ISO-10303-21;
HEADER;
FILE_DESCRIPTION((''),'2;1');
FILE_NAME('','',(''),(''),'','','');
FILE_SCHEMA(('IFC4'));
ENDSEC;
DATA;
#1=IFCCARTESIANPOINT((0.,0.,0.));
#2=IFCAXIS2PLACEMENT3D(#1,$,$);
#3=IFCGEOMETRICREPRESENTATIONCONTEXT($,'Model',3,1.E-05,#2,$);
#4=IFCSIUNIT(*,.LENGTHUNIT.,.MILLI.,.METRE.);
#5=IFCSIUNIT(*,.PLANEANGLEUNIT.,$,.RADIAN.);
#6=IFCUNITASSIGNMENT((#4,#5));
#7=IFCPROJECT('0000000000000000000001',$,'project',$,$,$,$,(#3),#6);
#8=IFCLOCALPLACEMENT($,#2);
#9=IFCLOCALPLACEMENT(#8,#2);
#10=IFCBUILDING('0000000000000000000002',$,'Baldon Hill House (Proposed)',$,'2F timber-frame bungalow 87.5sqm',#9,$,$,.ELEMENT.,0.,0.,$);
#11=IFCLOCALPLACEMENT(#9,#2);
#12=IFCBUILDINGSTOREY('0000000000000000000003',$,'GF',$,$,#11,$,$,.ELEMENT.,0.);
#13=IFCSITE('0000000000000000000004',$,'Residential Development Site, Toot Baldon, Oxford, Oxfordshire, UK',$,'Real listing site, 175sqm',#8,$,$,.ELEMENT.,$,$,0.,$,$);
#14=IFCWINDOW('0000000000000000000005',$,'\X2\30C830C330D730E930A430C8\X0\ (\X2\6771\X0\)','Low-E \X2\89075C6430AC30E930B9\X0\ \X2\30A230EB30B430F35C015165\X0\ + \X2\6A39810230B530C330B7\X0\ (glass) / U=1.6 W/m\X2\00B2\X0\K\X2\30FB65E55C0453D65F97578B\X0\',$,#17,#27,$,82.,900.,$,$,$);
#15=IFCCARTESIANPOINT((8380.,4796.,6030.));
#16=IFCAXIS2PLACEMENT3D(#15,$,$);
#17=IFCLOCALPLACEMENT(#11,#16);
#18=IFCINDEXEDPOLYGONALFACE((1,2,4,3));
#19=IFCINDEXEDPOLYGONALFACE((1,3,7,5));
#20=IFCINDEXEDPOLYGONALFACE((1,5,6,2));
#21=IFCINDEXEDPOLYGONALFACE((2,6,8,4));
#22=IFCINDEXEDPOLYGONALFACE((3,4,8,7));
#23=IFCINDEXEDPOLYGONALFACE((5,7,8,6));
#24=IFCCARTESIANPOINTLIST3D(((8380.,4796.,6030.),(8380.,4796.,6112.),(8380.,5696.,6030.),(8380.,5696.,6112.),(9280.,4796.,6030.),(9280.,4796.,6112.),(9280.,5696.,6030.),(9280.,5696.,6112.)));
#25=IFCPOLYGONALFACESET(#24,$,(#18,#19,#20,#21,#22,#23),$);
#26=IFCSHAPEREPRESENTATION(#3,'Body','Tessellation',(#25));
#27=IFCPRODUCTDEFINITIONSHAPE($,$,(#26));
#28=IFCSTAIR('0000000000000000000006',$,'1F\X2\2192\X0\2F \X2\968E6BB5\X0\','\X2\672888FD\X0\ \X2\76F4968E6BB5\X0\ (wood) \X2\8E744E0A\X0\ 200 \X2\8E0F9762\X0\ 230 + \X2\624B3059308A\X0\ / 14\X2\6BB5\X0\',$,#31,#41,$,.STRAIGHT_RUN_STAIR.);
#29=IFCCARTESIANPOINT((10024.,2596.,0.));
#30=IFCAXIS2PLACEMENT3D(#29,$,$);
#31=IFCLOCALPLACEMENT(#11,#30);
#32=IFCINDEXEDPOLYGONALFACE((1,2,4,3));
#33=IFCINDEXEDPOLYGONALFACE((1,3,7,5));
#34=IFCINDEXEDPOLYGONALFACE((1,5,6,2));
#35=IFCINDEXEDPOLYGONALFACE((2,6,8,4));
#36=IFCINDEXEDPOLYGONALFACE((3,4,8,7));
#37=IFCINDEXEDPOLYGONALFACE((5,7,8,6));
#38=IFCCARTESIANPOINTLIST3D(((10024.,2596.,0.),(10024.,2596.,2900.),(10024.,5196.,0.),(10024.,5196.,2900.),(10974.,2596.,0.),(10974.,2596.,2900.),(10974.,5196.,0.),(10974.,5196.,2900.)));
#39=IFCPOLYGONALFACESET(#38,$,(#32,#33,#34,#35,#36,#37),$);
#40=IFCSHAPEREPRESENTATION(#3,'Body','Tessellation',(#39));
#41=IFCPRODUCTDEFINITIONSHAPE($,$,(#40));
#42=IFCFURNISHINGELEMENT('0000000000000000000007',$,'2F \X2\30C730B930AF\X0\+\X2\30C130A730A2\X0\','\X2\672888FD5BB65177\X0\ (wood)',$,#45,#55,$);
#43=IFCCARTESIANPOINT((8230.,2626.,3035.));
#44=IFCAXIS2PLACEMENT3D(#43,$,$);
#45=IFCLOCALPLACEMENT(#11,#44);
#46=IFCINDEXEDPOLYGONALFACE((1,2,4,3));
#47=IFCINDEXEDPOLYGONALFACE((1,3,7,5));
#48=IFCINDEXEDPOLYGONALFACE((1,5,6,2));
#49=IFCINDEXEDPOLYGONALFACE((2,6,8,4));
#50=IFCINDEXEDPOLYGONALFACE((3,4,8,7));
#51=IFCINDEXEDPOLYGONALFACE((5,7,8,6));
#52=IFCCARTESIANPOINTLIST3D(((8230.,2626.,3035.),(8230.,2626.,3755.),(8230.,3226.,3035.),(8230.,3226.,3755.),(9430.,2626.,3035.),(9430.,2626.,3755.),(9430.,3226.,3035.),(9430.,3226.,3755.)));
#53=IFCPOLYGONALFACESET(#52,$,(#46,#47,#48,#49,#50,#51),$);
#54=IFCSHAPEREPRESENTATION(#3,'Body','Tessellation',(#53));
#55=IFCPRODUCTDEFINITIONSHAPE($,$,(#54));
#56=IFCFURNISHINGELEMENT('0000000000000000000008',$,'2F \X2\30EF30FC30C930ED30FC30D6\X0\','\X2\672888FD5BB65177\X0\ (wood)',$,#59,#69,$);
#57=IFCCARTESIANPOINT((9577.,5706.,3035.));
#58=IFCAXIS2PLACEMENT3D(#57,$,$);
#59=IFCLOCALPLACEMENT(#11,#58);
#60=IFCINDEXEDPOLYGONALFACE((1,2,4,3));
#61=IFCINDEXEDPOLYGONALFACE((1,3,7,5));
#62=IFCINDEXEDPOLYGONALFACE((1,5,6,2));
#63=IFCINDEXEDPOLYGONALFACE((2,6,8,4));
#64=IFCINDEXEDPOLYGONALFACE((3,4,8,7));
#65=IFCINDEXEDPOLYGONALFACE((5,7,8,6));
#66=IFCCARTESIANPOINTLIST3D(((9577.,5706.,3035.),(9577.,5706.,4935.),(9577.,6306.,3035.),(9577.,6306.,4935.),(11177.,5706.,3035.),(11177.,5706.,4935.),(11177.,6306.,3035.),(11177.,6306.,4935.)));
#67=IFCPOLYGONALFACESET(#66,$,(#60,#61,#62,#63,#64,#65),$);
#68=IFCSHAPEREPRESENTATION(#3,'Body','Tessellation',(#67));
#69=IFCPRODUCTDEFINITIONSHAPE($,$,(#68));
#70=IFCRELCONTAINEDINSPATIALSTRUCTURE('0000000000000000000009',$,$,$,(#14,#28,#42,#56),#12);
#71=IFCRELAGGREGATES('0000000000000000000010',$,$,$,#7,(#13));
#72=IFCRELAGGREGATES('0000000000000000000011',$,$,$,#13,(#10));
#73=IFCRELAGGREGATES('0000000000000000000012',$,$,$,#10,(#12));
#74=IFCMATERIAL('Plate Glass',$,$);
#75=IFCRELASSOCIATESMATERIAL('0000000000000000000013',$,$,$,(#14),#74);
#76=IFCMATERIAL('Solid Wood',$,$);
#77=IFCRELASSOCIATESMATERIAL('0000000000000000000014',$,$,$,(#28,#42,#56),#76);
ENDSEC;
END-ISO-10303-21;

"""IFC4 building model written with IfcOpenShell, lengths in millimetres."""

from ifc_helpers import new_model, si_unit, frame, frame_2d, origin, place, context, project, spatial, rectangle, extrude, material, element, save


model = new_model("IFC4")

# Units and contexts
model_context = context("Model", 3, precision=1e-05, world=origin())
ifc_project = project(units=[si_unit("LENGTHUNIT", "METRE", prefix="MILLI"), si_unit("PLANEANGLEUNIT", "RADIAN")], contexts=[model_context])

# Site, building, storey
site_placement = place(None, origin())
site = spatial("IfcSite", under=ifc_project, at=site_placement, Name="Residential Development Site, Toot Baldon, Oxford, Oxfordshire, UK", ObjectType="Real listing site, 175sqm", CompositionType="ELEMENT", RefElevation=0.0)
building_placement = place(site_placement, origin())
building = spatial("IfcBuilding", under=site, at=building_placement, Name="Baldon Hill House (Proposed)", ObjectType="2F timber-frame bungalow 87.5sqm", CompositionType="ELEMENT", ElevationOfRefHeight=0.0, ElevationOfTerrain=0.0)
storey_placement = place(building_placement, origin())
storey = spatial("IfcBuildingStorey", under=building, at=storey_placement, Name="GF", CompositionType="ELEMENT", Elevation=0.0)

# Shared definitions
ifc_material_1 = material(Name="Solid Wood")

# Shared definitions
ifc_material_2 = material(Name="Plate Glass")

# Window
window_1_placement = place(storey_placement, frame((8380.0, 4796.0, 6030.0)))
element("IfcWindow", 1, at=window_1_placement, inside=storey, material=ifc_material_2, Name="トップライト (東)", Description="Low-E 複層ガラス アルゴン封入 + 樹脂サッシ (glass) / U=1.6 W/m²K・日射取得型", OverallHeight=82.0, OverallWidth=900.0, context=model_context, shape_type="SweptSolid", body=[
    extrude(rectangle(XDim=900.0, YDim=900.0, at=frame_2d((450.0, 450.0))), frame((8380.0, 4796.0, 6030.0)), (0.0, 0.0, 1.0), 82.0),
])

# Stair
stair_placement = place(storey_placement, frame((10024.0, 2596.0, 0.0)))
element("IfcStair", 2, at=stair_placement, inside=storey, material=ifc_material_1, Name="1F→2F 階段", Description="木製 直階段 (wood) 蹴上 200 踏面 230 + 手すり / 14段", PredefinedType="STRAIGHT_RUN_STAIR", context=model_context, shape_type="SweptSolid", body=[
    extrude(rectangle(XDim=950.0, YDim=2600.0, at=frame_2d((475.0, 1300.0))), frame((10024.0, 2596.0, 0.0)), (0.0, 0.0, 1.0), 2900.0),
])

# Furnishing elements
furnishing_1_placement = place(storey_placement, frame((8230.0, 2626.0, 3035.0)))
element("IfcFurnishingElement", 3, at=furnishing_1_placement, inside=storey, material=ifc_material_1, Name="2F デスク+チェア", Description="木製家具 (wood)", context=model_context, shape_type="SweptSolid", body=[
    extrude(rectangle(XDim=1200.0, YDim=600.0, at=frame_2d((600.0, 300.0))), frame((8230.0, 2626.0, 3035.0)), (0.0, 0.0, 1.0), 720.0),
])
furnishing_2_placement = place(storey_placement, frame((9577.0, 5706.0, 3035.0)))
element("IfcFurnishingElement", 4, at=furnishing_2_placement, inside=storey, material=ifc_material_1, Name="2F ワードローブ", Description="木製家具 (wood)", context=model_context, shape_type="SweptSolid", body=[
    extrude(rectangle(XDim=1600.0, YDim=600.0, at=frame_2d((800.0, 300.0))), frame((9577.0, 5706.0, 3035.0)), (0.0, 0.0, 1.0), 1900.0),
])

save(model, "model.ifc")
